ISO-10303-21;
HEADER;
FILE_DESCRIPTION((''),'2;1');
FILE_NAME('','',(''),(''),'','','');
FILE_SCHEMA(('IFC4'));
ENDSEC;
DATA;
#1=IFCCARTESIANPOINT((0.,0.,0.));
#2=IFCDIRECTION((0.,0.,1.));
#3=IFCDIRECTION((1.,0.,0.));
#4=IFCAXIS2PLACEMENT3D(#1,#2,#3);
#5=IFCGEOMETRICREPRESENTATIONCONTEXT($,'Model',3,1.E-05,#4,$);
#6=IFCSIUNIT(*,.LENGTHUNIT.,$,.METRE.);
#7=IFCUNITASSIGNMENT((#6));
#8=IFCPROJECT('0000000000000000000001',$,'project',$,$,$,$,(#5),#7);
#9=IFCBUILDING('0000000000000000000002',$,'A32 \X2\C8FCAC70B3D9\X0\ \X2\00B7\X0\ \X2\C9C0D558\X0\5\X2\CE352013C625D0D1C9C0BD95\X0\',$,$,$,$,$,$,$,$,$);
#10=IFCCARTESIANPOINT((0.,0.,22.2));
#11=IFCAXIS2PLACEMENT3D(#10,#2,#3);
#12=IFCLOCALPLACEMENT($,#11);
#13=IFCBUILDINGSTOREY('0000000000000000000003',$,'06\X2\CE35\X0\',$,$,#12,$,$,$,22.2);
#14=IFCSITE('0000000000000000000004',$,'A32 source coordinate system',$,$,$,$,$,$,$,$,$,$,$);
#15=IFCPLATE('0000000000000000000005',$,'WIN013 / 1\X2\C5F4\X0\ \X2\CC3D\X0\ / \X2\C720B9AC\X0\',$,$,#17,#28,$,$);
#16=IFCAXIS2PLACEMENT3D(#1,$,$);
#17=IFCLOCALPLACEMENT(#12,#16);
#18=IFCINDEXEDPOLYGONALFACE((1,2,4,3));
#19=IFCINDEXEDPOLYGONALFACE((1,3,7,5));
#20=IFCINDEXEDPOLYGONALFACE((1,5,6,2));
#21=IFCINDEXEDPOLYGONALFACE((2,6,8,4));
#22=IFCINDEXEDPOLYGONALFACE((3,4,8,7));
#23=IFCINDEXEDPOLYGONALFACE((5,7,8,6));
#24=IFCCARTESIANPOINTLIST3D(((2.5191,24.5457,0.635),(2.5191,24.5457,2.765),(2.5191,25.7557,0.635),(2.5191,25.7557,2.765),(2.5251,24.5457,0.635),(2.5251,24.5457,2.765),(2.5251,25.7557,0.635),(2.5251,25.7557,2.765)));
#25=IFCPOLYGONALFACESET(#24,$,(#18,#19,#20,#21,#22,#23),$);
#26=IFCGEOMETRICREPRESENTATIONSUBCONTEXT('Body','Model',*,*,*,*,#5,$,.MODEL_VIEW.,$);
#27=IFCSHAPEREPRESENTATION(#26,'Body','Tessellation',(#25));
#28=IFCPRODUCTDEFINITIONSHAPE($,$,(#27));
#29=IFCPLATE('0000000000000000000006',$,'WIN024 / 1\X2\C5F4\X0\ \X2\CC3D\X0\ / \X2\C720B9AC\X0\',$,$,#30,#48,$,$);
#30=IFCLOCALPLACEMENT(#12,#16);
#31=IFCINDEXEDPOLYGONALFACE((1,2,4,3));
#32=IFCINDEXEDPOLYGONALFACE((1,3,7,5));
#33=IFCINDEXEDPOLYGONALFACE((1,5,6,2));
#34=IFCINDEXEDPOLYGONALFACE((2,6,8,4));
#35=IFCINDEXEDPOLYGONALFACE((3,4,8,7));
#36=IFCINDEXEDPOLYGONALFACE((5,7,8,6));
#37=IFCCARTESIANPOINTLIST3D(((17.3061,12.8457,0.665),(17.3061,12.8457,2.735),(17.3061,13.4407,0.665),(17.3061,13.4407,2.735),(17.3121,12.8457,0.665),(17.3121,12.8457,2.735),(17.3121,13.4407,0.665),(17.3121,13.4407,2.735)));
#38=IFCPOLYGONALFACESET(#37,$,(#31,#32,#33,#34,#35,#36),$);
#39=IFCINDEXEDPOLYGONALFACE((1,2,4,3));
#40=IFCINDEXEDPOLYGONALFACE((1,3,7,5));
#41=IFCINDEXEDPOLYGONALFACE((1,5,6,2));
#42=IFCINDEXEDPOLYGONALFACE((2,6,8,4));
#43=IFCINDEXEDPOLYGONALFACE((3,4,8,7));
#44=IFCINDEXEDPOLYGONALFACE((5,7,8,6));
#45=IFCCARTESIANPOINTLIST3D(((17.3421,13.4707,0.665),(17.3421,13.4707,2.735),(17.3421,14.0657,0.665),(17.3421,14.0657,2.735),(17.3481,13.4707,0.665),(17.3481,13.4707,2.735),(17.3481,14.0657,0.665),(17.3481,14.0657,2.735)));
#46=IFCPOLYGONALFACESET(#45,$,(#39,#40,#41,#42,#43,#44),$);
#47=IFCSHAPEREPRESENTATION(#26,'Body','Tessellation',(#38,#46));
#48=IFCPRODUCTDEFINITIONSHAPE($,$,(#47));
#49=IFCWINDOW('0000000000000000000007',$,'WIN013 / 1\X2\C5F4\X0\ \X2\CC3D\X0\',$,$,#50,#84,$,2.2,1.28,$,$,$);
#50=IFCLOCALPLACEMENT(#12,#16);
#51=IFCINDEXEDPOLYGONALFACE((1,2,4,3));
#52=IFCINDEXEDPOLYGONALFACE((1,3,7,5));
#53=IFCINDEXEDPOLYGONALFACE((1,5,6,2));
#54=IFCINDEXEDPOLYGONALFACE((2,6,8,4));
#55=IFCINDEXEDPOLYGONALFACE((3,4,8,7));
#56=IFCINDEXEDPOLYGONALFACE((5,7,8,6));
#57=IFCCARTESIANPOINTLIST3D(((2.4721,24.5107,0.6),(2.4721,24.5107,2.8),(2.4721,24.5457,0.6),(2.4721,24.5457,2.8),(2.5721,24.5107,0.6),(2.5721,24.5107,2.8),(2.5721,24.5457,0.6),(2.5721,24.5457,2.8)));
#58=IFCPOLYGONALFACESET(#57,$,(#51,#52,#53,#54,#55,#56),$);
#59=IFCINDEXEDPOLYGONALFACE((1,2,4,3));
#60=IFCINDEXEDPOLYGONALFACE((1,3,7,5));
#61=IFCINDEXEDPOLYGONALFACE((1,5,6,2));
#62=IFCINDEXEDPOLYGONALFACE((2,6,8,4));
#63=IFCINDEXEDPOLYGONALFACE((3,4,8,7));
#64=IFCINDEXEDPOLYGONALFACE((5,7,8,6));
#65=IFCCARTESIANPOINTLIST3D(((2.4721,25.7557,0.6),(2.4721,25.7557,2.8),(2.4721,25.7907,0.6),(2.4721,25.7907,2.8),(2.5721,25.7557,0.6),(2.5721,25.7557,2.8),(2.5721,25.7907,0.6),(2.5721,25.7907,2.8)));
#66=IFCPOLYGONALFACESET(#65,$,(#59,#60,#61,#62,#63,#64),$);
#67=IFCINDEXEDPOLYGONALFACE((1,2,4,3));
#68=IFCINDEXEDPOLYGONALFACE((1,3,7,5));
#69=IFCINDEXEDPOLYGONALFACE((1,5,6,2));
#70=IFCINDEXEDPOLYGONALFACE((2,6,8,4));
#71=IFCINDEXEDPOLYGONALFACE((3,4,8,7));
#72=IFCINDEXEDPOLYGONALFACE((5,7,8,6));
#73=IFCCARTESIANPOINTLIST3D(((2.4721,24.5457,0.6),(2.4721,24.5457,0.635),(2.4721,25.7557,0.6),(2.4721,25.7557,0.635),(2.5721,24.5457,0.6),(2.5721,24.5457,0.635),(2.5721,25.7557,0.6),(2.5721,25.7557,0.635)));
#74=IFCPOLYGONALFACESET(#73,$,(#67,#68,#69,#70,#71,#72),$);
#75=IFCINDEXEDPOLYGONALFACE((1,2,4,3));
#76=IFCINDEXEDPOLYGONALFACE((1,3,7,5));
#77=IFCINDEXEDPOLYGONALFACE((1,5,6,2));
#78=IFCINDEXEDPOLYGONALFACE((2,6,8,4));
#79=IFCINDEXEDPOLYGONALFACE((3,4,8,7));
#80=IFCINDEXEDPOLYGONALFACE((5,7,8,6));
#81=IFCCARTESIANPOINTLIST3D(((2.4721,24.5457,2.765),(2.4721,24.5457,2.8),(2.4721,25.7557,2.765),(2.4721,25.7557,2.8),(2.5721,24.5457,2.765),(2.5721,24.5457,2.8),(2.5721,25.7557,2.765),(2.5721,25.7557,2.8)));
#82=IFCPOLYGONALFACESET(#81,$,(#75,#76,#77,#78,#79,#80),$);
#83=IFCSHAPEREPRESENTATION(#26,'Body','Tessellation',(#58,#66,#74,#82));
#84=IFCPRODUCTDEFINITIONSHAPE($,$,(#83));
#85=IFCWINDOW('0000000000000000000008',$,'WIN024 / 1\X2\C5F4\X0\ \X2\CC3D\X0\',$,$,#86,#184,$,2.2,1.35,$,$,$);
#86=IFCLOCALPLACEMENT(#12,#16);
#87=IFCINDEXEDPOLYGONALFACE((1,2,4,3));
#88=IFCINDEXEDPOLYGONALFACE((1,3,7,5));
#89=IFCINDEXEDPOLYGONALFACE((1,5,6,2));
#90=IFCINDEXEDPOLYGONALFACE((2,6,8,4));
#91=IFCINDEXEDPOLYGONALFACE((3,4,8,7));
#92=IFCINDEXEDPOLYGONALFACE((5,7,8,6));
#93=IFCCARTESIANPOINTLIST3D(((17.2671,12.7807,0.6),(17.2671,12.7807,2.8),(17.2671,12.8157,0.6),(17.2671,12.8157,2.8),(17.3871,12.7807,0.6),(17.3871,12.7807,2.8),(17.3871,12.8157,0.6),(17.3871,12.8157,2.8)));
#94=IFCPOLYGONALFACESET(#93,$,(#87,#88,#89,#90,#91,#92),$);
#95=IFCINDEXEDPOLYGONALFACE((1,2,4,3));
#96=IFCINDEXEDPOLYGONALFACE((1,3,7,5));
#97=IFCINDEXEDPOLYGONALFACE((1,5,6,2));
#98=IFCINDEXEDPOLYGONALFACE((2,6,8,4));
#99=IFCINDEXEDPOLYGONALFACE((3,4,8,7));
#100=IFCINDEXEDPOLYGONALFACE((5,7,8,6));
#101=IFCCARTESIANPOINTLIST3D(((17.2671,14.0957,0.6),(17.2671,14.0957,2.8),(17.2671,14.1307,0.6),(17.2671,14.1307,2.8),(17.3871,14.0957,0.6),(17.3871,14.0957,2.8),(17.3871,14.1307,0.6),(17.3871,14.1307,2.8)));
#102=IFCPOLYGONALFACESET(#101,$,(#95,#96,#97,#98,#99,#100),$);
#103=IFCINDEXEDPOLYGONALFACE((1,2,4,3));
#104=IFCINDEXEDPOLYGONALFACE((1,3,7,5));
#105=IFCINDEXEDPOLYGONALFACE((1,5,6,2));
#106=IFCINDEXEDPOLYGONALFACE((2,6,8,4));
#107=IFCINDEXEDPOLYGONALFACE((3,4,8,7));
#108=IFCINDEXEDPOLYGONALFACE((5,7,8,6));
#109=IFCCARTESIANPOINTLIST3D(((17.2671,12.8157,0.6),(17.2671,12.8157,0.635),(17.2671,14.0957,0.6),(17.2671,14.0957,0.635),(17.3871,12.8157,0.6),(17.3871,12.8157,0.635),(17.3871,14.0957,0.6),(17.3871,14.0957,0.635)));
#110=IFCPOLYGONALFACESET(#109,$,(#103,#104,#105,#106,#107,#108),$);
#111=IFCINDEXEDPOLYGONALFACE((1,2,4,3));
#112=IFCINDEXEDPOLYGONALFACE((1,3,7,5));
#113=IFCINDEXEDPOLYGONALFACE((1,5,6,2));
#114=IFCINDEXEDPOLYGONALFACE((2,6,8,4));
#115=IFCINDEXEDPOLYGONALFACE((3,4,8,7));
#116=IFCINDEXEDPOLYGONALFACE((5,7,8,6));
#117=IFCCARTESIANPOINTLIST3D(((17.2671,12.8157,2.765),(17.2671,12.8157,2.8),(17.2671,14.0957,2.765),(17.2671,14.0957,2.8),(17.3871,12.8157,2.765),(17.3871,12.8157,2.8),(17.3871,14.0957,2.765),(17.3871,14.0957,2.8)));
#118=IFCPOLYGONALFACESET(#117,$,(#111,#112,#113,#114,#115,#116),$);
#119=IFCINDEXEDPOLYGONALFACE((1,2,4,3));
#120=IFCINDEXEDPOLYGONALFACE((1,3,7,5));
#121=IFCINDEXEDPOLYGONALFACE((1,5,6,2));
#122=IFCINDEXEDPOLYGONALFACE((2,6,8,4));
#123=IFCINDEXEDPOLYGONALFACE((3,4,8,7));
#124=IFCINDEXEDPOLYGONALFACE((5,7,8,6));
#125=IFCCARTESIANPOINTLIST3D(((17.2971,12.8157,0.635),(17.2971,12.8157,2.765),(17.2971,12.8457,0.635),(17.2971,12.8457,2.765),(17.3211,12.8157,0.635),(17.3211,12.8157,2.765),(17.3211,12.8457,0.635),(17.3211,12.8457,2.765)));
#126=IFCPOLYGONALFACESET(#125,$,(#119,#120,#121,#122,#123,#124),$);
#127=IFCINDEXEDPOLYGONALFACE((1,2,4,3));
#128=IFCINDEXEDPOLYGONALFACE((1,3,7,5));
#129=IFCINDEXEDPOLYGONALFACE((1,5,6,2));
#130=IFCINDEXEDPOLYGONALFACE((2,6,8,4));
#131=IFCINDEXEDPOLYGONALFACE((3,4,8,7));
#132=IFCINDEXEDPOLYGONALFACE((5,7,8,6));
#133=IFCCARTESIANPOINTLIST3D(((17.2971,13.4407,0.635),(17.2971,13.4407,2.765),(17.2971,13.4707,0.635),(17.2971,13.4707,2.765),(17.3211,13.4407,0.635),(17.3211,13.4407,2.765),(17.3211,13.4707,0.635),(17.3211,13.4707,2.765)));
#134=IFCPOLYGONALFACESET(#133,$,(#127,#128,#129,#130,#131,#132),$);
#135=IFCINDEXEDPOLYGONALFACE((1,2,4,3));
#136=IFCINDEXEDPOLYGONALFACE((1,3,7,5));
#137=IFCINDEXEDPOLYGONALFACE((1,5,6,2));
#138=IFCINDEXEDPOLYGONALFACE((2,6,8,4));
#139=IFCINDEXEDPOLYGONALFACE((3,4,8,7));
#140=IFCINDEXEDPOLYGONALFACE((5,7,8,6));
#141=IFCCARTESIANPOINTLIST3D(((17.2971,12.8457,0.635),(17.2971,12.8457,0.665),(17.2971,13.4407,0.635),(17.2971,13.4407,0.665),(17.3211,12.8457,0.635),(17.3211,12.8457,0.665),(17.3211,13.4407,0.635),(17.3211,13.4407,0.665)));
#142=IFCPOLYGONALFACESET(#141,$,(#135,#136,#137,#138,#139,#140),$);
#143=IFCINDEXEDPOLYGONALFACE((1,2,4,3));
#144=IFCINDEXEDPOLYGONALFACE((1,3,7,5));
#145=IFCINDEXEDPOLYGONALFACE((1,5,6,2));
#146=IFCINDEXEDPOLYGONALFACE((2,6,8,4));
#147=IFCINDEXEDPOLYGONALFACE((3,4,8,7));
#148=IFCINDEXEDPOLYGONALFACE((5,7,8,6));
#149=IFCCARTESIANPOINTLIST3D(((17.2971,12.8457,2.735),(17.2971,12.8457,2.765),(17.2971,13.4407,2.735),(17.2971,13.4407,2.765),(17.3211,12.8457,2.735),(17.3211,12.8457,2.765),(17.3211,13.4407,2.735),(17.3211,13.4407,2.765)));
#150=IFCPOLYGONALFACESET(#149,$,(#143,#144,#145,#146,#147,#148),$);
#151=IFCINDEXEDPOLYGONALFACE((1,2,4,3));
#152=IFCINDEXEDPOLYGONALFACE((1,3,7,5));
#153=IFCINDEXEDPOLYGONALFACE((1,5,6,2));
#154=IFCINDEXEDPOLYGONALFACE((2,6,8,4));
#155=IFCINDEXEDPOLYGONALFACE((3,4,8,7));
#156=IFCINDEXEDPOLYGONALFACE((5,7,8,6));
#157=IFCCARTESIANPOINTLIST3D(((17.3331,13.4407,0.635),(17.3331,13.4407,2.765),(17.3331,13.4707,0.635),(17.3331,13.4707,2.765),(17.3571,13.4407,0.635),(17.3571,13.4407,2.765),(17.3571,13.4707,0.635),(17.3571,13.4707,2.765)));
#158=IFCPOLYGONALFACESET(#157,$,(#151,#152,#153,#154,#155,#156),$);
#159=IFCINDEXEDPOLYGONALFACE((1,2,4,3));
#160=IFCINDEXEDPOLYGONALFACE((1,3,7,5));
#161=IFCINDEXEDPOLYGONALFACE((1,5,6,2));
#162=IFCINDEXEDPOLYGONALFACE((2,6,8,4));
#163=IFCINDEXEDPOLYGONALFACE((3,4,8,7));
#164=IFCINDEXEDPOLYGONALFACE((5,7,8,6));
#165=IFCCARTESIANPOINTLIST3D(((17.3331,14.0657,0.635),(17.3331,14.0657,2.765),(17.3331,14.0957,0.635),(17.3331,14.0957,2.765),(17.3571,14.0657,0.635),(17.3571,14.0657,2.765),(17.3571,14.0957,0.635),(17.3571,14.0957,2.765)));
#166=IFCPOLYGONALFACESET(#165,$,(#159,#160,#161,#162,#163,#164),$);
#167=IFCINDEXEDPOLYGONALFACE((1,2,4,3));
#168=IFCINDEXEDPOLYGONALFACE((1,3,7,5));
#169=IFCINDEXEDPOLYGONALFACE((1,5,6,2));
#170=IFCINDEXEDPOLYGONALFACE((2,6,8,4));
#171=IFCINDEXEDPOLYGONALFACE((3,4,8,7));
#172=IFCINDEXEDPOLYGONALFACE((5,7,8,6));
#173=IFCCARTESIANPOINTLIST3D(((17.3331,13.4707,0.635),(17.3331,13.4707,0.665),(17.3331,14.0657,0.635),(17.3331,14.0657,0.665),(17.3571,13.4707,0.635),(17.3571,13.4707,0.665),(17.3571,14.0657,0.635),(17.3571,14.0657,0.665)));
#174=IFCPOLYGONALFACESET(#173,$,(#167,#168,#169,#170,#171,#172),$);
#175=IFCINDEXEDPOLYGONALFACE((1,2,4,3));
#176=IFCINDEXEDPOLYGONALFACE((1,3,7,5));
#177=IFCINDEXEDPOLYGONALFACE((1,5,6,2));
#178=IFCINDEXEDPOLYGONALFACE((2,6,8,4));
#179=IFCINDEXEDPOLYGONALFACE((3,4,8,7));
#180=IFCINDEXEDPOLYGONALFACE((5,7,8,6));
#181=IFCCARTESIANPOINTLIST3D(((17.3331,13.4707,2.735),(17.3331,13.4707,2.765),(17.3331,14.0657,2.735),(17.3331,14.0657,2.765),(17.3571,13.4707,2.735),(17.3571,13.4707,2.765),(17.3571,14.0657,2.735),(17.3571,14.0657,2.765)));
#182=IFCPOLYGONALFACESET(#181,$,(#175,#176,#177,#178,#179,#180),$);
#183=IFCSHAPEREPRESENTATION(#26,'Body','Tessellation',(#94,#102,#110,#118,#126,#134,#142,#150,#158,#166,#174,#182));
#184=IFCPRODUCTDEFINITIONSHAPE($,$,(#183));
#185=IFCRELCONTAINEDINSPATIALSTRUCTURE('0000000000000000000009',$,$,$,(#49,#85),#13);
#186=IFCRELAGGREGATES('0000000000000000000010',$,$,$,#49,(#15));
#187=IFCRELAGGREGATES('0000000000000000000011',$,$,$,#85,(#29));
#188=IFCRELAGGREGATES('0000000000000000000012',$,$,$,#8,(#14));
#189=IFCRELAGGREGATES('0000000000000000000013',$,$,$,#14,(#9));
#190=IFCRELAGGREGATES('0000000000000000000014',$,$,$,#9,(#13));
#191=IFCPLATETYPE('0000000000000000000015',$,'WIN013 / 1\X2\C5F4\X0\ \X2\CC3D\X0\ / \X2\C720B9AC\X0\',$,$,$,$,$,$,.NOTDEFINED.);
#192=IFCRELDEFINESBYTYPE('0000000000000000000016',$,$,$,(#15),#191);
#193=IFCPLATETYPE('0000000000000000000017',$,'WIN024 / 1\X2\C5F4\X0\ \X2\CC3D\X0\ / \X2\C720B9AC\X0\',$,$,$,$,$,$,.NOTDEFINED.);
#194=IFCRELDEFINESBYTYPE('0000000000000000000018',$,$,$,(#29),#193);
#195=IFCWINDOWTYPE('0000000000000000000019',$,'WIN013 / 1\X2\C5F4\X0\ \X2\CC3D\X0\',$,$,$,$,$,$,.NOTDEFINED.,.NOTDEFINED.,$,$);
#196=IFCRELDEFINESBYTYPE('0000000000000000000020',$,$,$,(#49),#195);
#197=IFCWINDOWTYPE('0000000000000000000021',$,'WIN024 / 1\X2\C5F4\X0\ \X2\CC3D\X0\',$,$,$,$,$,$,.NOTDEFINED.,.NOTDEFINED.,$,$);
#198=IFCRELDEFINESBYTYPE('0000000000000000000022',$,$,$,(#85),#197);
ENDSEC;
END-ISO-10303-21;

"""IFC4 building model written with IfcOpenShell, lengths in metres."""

from ifc_helpers import new_model, si_unit, frame, origin, origin_with_axes, place, context, subcontext, project, spatial, polyline, outline, extrude, source, transform, mapped, type_object, type_shapes, element, aggregate, save


model = new_model("IFC4")

# Units and contexts
model_context = context("Model", 3, precision=1e-05, world=origin_with_axes())
body_context = subcontext(model_context, "Body", "Model", "MODEL_VIEW")
ifc_project = project(units=[si_unit("LENGTHUNIT", "METRE")], contexts=[model_context])

# Plates
plate_type_1 = type_object("IfcPlateType", Name="WIN013 / 1열 창 / 유리", PredefinedType="NOTDEFINED")
shared_shape_1 = source(origin(), body_context, "Body", "SweptSolid", [
    extrude(outline(polyline([(2.5191, 24.5457), (2.5191, 25.7557), (2.5251, 25.7557), (2.5251, 24.5457), (2.5191, 24.5457)])), frame((0.0, 0.0, 0.635)), (0.0, 0.0, 1.0), 2.13),
])
type_shapes(plate_type_1, [shared_shape_1])
storey_placement = place(None, frame((0.0, 0.0, 22.2), z_axis=(0.0, 0.0, 1.0), x_axis=(1.0, 0.0, 0.0)))
window_1_placement = place(storey_placement, origin_with_axes())
plate_1_placement = place(window_1_placement, origin_with_axes())
plate_1 = element("IfcPlate", 1, at=plate_1_placement, type_object=plate_type_1, Name="WIN013 / 1열 창 / 유리", context=body_context, shape_type="MappedRepresentation", body=[
    mapped(shared_shape_1, transform((0.0, 0.0, 0.0), scale=1.0)),
])
plate_type_2 = type_object("IfcPlateType", Name="WIN024 / 1열 창 / 유리", PredefinedType="NOTDEFINED")
shared_shape_2 = source(origin(), body_context, "Body", "SweptSolid", [
    extrude(outline(polyline([(17.3061, 12.8457), (17.3061, 13.4407), (17.3121, 13.4407), (17.3121, 12.8457), (17.3061, 12.8457)])), frame((0.0, 0.0, 0.665)), (0.0, 0.0, 1.0), 2.07),
    extrude(outline(polyline([(17.3421, 13.4707), (17.3421, 14.0657), (17.3481, 14.0657), (17.3481, 13.4707), (17.3421, 13.4707)])), frame((0.0, 0.0, 0.665)), (0.0, 0.0, 1.0), 2.07),
])
type_shapes(plate_type_2, [shared_shape_2])
window_2_placement = place(storey_placement, origin_with_axes())
plate_2_placement = place(window_2_placement, origin_with_axes())
plate_2 = element("IfcPlate", 2, at=plate_2_placement, type_object=plate_type_2, Name="WIN024 / 1열 창 / 유리", context=body_context, shape_type="MappedRepresentation", body=[
    mapped(shared_shape_2, transform((0.0, 0.0, 0.0), scale=1.0)),
])

# Site, building, storey
site = spatial("IfcSite", under=ifc_project, Name="A32 source coordinate system")
building = spatial("IfcBuilding", under=site, Name="A32 주거동 · 지하5층–옥탑지붕")
storey = spatial("IfcBuildingStorey", under=building, at=storey_placement, Name="06층", Elevation=22.2)

# Windows
window_type_1 = type_object("IfcWindowType", Name="WIN013 / 1열 창", PartitioningType="NOTDEFINED", PredefinedType="NOTDEFINED")
shared_shape_3 = source(origin(), body_context, "Body", "SweptSolid", [
    extrude(outline(polyline([(2.4721, 24.5107), (2.4721, 24.5457), (2.5721, 24.5457), (2.5721, 24.5107), (2.4721, 24.5107)])), frame((0.0, 0.0, 0.6)), (0.0, 0.0, 1.0), 2.2),
    extrude(outline(polyline([(2.4721, 25.7557), (2.4721, 25.7907), (2.5721, 25.7907), (2.5721, 25.7557), (2.4721, 25.7557)])), frame((0.0, 0.0, 0.6)), (0.0, 0.0, 1.0), 2.2),
    extrude(outline(polyline([(2.4721, 24.5457), (2.4721, 25.7557), (2.5721, 25.7557), (2.5721, 24.5457), (2.4721, 24.5457)])), frame((0.0, 0.0, 0.6)), (0.0, 0.0, 1.0), 0.035),
    extrude(outline(polyline([(2.4721, 24.5457), (2.4721, 25.7557), (2.5721, 25.7557), (2.5721, 24.5457), (2.4721, 24.5457)])), frame((0.0, 0.0, 2.765)), (0.0, 0.0, 1.0), 0.035),
])
type_shapes(window_type_1, [shared_shape_3])
window_1 = element("IfcWindow", 3, at=window_1_placement, inside=storey, type_object=window_type_1, Name="WIN013 / 1열 창", OverallHeight=2.2, OverallWidth=1.28, context=body_context, shape_type="MappedRepresentation", body=[
    mapped(shared_shape_3, transform((0.0, 0.0, 0.0), scale=1.0)),
])
aggregate(window_1, [plate_1])
window_type_2 = type_object("IfcWindowType", Name="WIN024 / 1열 창", PartitioningType="NOTDEFINED", PredefinedType="NOTDEFINED")
shared_shape_4 = source(origin(), body_context, "Body", "SweptSolid", [
    extrude(outline(polyline([(17.2671, 12.7807), (17.2671, 12.8157), (17.3871, 12.8157), (17.3871, 12.7807), (17.2671, 12.7807)])), frame((0.0, 0.0, 0.6)), (0.0, 0.0, 1.0), 2.2),
    extrude(outline(polyline([(17.2671, 14.0957), (17.2671, 14.1307), (17.3871, 14.1307), (17.3871, 14.0957), (17.2671, 14.0957)])), frame((0.0, 0.0, 0.6)), (0.0, 0.0, 1.0), 2.2),
    extrude(outline(polyline([(17.2671, 12.8157), (17.2671, 14.0957), (17.3871, 14.0957), (17.3871, 12.8157), (17.2671, 12.8157)])), frame((0.0, 0.0, 0.6)), (0.0, 0.0, 1.0), 0.035),
    extrude(outline(polyline([(17.2671, 12.8157), (17.2671, 14.0957), (17.3871, 14.0957), (17.3871, 12.8157), (17.2671, 12.8157)])), frame((0.0, 0.0, 2.765)), (0.0, 0.0, 1.0), 0.035),
    extrude(outline(polyline([(17.2971, 12.8157), (17.2971, 12.8457), (17.3211, 12.8457), (17.3211, 12.8157), (17.2971, 12.8157)])), frame((0.0, 0.0, 0.635)), (0.0, 0.0, 1.0), 2.13),
    extrude(outline(polyline([(17.2971, 13.4407), (17.2971, 13.4707), (17.3211, 13.4707), (17.3211, 13.4407), (17.2971, 13.4407)])), frame((0.0, 0.0, 0.635)), (0.0, 0.0, 1.0), 2.13),
    extrude(outline(polyline([(17.2971, 12.8457), (17.2971, 13.4407), (17.3211, 13.4407), (17.3211, 12.8457), (17.2971, 12.8457)])), frame((0.0, 0.0, 0.635)), (0.0, 0.0, 1.0), 0.03),
    extrude(outline(polyline([(17.2971, 12.8457), (17.2971, 13.4407), (17.3211, 13.4407), (17.3211, 12.8457), (17.2971, 12.8457)])), frame((0.0, 0.0, 2.735)), (0.0, 0.0, 1.0), 0.03),
    extrude(outline(polyline([(17.3331, 13.4407), (17.3331, 13.4707), (17.3571, 13.4707), (17.3571, 13.4407), (17.3331, 13.4407)])), frame((0.0, 0.0, 0.635)), (0.0, 0.0, 1.0), 2.13),
    extrude(outline(polyline([(17.3331, 14.0657), (17.3331, 14.0957), (17.3571, 14.0957), (17.3571, 14.0657), (17.3331, 14.0657)])), frame((0.0, 0.0, 0.635)), (0.0, 0.0, 1.0), 2.13),
    extrude(outline(polyline([(17.3331, 13.4707), (17.3331, 14.0657), (17.3571, 14.0657), (17.3571, 13.4707), (17.3331, 13.4707)])), frame((0.0, 0.0, 0.635)), (0.0, 0.0, 1.0), 0.03),
    extrude(outline(polyline([(17.3331, 13.4707), (17.3331, 14.0657), (17.3571, 14.0657), (17.3571, 13.4707), (17.3331, 13.4707)])), frame((0.0, 0.0, 2.735)), (0.0, 0.0, 1.0), 0.03),
])
type_shapes(window_type_2, [shared_shape_4])
window_2 = element("IfcWindow", 4, at=window_2_placement, inside=storey, type_object=window_type_2, Name="WIN024 / 1열 창", OverallHeight=2.2, OverallWidth=1.35, context=body_context, shape_type="MappedRepresentation", body=[
    mapped(shared_shape_4, transform((0.0, 0.0, 0.0), scale=1.0)),
])
aggregate(window_2, [plate_2])

save(model, "model.ifc")
